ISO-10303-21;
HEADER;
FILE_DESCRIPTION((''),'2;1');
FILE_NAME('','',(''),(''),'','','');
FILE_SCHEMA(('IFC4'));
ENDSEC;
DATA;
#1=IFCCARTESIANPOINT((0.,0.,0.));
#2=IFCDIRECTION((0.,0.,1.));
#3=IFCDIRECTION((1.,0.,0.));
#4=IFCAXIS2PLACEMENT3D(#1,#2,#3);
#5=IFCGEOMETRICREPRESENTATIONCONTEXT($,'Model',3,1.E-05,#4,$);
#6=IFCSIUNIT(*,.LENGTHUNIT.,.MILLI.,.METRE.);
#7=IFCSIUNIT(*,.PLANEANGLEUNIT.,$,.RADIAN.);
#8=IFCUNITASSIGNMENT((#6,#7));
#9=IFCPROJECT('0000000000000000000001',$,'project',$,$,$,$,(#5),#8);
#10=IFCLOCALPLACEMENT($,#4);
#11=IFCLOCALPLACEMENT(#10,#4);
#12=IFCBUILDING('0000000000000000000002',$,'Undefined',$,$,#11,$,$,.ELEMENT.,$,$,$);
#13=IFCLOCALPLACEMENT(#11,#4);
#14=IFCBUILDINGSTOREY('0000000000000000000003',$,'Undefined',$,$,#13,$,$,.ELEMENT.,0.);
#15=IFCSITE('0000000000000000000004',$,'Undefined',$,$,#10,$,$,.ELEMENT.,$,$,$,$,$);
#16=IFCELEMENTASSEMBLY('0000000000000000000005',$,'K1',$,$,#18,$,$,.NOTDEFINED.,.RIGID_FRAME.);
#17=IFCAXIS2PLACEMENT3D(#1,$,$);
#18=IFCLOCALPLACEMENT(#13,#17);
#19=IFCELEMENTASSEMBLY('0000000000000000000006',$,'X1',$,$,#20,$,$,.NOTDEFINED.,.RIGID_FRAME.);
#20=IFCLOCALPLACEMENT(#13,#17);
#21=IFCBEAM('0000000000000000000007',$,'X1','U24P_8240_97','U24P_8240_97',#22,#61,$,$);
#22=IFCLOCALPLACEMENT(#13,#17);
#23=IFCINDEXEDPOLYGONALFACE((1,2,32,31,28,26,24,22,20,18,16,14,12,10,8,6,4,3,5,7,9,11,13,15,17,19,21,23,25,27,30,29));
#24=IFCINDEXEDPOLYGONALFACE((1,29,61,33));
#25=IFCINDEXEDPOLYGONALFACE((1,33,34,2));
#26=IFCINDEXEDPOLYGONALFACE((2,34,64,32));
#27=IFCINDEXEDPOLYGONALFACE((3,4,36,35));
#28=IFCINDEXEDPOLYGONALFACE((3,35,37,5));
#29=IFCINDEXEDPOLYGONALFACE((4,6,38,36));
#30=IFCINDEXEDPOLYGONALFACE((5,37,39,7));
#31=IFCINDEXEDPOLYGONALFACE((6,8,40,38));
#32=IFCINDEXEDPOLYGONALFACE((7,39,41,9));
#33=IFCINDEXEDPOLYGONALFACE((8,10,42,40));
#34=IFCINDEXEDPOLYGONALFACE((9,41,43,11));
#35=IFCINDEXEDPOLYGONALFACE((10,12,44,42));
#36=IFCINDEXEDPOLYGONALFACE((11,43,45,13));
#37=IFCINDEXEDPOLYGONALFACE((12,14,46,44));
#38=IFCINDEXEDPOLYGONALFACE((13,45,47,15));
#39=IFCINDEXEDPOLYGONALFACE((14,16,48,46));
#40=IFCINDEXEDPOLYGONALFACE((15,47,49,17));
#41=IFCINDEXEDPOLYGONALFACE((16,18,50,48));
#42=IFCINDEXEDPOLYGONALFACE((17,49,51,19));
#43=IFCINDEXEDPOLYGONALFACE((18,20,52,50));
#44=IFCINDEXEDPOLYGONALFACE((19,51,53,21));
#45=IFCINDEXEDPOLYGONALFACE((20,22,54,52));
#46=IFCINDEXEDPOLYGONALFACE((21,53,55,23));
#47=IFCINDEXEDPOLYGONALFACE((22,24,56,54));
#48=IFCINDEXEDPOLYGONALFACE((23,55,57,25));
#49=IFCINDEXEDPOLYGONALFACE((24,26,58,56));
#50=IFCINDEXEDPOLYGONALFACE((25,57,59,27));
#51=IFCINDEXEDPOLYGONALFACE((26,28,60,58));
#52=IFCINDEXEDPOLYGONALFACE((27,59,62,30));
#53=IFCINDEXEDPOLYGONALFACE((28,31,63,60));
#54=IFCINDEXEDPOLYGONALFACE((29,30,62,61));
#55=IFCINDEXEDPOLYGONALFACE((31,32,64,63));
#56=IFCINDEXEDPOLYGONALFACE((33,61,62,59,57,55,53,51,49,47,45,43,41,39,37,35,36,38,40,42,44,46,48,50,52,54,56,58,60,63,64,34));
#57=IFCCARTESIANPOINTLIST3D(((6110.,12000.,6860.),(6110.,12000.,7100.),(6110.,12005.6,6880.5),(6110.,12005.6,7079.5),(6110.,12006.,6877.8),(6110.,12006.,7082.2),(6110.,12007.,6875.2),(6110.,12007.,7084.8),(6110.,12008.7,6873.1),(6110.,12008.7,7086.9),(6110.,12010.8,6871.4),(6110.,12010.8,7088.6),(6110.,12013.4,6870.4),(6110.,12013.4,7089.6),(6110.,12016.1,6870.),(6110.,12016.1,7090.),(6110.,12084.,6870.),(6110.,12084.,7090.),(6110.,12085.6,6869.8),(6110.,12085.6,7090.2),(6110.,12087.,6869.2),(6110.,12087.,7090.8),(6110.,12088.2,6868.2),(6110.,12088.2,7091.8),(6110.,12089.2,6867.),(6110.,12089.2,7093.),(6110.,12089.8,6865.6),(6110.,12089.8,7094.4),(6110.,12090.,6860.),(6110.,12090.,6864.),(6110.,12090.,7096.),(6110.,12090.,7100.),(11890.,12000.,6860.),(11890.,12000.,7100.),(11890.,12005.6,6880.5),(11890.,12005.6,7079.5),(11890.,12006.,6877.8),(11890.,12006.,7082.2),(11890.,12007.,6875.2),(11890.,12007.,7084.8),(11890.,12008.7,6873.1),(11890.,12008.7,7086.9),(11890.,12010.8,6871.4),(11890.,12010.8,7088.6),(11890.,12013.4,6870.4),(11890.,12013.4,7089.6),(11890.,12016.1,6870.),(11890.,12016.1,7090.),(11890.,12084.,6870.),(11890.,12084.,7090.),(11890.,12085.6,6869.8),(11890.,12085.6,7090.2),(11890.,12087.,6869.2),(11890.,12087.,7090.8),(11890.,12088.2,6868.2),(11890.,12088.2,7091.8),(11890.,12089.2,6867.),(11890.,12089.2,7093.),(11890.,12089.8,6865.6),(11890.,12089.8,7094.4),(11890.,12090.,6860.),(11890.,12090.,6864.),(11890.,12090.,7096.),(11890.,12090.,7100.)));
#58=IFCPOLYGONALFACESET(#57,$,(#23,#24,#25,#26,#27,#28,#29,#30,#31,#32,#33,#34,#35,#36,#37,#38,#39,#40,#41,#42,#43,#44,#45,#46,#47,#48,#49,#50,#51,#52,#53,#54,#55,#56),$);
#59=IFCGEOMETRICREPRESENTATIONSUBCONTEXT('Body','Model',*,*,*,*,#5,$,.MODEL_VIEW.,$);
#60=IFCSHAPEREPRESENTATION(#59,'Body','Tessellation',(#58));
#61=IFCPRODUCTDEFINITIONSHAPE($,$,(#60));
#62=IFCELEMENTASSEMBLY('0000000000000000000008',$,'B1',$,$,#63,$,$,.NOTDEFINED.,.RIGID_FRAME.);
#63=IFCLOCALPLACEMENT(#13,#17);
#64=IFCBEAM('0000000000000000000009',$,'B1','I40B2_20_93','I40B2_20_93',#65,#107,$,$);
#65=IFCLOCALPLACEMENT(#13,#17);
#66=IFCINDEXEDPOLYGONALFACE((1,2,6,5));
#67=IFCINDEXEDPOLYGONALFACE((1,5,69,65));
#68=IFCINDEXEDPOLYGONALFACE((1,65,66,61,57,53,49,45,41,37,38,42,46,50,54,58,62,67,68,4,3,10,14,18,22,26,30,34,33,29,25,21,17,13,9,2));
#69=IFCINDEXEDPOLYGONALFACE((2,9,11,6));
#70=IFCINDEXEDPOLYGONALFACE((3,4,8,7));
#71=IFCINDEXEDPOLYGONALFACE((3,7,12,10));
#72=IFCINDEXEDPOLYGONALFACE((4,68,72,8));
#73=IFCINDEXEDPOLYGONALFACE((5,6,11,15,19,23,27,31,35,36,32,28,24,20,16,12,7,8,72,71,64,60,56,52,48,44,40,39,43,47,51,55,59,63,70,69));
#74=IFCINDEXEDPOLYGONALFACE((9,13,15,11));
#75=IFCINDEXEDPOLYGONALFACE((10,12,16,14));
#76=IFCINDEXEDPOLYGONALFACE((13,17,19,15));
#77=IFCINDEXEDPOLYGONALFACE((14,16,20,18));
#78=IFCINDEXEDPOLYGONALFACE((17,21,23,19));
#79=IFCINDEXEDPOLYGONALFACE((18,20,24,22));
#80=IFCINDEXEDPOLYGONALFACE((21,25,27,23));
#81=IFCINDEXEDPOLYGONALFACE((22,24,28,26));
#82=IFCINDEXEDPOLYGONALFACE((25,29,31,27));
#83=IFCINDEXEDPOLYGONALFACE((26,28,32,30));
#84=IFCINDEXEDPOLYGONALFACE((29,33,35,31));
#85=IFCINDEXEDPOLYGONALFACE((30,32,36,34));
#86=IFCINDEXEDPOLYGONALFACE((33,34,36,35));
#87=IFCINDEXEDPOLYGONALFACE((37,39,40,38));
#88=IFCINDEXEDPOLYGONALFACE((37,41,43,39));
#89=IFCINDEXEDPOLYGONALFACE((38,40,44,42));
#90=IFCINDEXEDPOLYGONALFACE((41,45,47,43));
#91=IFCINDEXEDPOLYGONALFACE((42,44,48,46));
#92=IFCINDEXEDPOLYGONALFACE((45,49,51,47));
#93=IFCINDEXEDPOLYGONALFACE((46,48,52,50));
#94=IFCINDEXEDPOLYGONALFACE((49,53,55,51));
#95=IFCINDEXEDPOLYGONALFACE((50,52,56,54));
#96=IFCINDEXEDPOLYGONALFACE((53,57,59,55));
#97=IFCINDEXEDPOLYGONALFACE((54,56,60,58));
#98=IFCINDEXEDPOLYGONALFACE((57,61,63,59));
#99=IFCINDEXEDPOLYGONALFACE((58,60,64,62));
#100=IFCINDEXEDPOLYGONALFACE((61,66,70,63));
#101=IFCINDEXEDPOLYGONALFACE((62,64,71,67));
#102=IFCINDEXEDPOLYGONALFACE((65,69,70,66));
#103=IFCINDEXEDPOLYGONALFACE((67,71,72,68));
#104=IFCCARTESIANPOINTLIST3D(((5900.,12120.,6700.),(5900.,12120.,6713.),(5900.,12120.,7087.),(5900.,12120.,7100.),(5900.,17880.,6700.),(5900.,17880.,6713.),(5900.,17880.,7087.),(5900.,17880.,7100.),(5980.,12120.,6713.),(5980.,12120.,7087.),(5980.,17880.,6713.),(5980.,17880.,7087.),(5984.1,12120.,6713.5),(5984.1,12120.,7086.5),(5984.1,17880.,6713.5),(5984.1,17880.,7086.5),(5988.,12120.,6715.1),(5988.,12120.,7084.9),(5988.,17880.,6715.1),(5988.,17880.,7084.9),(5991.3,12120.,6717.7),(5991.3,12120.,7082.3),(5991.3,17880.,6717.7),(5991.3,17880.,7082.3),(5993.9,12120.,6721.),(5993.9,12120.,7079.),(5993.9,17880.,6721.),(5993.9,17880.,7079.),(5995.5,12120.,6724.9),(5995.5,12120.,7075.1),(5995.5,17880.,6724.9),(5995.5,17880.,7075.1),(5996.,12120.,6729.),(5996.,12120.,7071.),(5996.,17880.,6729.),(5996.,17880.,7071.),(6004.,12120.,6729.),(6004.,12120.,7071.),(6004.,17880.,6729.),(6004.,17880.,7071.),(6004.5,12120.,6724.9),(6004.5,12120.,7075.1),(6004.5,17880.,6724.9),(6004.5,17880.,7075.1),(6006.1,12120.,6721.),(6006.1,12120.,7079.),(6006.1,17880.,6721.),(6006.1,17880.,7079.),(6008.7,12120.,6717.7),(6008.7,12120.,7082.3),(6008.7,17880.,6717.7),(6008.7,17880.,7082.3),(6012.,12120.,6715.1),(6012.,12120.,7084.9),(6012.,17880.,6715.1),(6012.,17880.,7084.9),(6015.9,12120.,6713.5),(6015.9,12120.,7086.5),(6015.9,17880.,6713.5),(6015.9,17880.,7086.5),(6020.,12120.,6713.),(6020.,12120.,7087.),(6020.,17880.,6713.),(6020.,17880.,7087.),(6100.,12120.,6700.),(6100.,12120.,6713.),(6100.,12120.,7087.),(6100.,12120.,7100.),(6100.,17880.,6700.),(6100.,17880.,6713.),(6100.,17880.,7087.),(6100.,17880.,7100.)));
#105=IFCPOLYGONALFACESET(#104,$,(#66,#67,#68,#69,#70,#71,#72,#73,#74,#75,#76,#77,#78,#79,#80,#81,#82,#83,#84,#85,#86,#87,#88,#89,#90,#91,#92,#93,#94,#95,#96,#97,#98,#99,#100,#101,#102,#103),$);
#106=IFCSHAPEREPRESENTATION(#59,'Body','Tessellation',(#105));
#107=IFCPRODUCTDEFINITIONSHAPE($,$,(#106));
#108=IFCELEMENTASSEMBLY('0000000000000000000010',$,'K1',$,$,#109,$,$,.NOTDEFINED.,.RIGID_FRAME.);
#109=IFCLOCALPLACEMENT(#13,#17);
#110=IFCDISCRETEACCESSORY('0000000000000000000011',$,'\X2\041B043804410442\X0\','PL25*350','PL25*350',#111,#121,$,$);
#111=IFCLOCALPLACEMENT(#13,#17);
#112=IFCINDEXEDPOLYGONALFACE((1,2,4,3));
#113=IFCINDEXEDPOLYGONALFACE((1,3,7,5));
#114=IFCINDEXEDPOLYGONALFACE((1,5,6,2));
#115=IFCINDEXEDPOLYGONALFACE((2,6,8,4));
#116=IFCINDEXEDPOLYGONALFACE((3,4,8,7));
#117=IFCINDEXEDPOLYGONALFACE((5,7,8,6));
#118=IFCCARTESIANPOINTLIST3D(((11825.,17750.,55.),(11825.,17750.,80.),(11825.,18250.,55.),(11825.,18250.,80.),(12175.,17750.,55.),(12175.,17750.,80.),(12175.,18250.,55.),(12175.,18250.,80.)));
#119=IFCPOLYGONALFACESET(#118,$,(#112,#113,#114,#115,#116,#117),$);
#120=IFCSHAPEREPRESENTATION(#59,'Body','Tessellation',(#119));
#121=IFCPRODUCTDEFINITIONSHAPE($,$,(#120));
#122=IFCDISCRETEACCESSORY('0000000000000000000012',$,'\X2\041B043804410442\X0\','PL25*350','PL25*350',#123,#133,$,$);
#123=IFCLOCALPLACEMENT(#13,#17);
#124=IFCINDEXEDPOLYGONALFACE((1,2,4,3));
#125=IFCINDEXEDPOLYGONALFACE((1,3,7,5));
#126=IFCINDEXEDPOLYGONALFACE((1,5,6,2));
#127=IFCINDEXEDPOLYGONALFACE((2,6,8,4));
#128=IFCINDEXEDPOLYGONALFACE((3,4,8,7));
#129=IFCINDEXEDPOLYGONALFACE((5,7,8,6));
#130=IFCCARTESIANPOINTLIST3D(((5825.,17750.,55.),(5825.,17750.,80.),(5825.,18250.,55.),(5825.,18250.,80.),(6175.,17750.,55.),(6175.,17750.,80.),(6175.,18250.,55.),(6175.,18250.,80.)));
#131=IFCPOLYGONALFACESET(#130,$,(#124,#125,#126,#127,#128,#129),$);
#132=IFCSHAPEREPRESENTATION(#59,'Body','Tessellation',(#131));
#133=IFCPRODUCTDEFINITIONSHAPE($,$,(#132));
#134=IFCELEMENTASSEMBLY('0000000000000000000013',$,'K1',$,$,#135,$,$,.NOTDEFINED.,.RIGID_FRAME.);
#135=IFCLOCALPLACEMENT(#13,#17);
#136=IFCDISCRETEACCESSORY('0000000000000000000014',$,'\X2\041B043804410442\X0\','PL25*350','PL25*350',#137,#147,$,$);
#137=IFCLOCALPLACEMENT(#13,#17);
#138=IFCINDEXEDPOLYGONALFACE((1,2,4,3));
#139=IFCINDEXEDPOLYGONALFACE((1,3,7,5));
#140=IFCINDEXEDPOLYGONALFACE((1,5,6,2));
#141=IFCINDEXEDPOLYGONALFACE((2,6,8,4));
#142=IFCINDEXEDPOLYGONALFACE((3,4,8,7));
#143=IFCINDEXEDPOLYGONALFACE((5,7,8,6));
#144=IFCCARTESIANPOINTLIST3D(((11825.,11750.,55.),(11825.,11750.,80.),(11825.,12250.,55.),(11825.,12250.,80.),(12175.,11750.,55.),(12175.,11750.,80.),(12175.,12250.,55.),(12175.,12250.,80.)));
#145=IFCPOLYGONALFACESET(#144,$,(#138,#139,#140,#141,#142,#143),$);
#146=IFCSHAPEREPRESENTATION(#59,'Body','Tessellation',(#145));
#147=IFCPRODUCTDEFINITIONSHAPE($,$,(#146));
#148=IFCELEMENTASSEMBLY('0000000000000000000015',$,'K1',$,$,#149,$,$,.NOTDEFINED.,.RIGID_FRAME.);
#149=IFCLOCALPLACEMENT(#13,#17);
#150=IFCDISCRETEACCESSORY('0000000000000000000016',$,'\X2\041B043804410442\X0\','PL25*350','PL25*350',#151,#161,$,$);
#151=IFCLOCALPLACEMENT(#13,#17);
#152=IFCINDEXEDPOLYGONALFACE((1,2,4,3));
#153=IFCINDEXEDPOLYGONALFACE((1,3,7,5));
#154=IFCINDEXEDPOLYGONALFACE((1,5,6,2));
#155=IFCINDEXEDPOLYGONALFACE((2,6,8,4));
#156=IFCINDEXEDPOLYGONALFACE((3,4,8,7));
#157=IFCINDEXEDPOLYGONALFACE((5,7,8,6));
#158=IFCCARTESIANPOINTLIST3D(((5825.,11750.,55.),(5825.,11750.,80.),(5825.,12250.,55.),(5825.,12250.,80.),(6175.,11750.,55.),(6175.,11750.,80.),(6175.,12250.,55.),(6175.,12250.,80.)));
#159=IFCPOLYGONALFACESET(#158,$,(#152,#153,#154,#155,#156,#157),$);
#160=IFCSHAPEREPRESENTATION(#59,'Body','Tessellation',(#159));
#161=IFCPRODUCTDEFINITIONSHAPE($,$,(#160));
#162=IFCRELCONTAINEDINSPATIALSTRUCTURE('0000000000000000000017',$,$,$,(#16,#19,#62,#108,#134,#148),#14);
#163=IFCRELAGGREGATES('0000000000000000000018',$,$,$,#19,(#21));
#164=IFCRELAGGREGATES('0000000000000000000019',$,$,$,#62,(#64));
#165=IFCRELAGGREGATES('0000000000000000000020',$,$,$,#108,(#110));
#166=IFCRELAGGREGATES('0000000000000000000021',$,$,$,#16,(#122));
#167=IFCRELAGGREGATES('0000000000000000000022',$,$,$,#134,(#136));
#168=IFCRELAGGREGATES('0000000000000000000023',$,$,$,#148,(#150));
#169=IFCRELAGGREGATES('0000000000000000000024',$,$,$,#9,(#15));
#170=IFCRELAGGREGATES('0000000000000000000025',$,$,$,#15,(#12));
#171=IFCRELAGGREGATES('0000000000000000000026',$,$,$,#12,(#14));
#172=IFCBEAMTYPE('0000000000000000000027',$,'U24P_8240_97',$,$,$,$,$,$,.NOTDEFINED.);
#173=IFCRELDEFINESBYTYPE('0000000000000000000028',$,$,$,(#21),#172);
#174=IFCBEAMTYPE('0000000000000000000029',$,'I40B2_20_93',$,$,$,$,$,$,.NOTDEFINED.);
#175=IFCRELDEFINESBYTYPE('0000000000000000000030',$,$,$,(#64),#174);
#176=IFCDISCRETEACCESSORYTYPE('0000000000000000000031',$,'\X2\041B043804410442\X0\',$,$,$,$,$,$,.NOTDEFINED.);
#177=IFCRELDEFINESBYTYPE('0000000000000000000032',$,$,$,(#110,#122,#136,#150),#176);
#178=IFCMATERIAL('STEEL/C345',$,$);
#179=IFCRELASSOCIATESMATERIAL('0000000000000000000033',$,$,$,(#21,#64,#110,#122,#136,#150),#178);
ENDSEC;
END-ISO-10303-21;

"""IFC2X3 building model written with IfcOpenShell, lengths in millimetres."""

from ifc_helpers import new_model, si_unit, frame, origin_with_axes, origin_2d_with_axis, place, context, subcontext, project, spatial, polyline, i_section, u_section, outline, extrude, material, type_object, element, aggregate, save


model = new_model("IFC2X3")

# Units and contexts
model_context = context("Model", 3, precision=1e-05, world=origin_with_axes())
body_context = subcontext(model_context, "Body", "Model", "MODEL_VIEW")
ifc_project = project(units=[si_unit("LENGTHUNIT", "METRE", prefix="MILLI"), si_unit("PLANEANGLEUNIT", "RADIAN")], contexts=[model_context])

# Site, building, storey
site_placement = place(None, origin_with_axes())
site = spatial("IfcSite", under=ifc_project, at=site_placement, Name="Undefined", CompositionType="ELEMENT")
building_placement = place(site_placement, origin_with_axes())
building = spatial("IfcBuilding", under=site, at=building_placement, Name="Undefined", CompositionType="ELEMENT")
storey_placement = place(building_placement, origin_with_axes())
storey = spatial("IfcBuildingStorey", under=building, at=storey_placement, Name="Undefined", CompositionType="ELEMENT", Elevation=0.0)

# Element assembly
assembly_1_placement = place(storey_placement, origin_with_axes())
assembly_1 = element("IfcElementAssembly", 1, at=assembly_1_placement, inside=storey, Name="K1", AssemblyPlace="NOTDEFINED", PredefinedType="RIGID_FRAME")
ifc_material_1 = material(Name="STEEL/C345")

# Element assemblies, beams
beam_type_1 = type_object("IfcBeamType", Name="U24P_8240_97", PredefinedType="NOTDEFINED")
assembly_2_placement = place(storey_placement, origin_with_axes())
assembly_2 = element("IfcElementAssembly", 2, at=assembly_2_placement, inside=storey, Name="X1", AssemblyPlace="NOTDEFINED", PredefinedType="RIGID_FRAME")
beam_1_placement = place(assembly_2_placement, frame((6110.0, 12045.0, 6980.0), z_axis=(0.0, 0.0, -1.0), x_axis=(1.0, 0.0, 0.0)))
beam_1 = element("IfcBeam", 3, at=beam_1_placement, type_object=beam_type_1, material=ifc_material_1, Name="X1", Description="U24P_8240_97", ObjectType="U24P_8240_97", context=body_context, shape_type="SweptSolid", body=[
    extrude(u_section(Depth=240.0, FlangeWidth=90.0, WebThickness=5.6, FlangeThickness=10.0, FilletRadius=10.5, EdgeRadius=6.0, at=origin_2d_with_axis()), frame((5780.0, 0.0, 0.0), z_axis=(-1.0, 0.0, 0.0), x_axis=(0.0, -1.0, 0.0)), (0.0, 0.0, 1.0), 5780.0),
])
aggregate(assembly_2, [beam_1])
assembly_3_placement = place(storey_placement, origin_with_axes())
assembly_3 = element("IfcElementAssembly", 4, at=assembly_3_placement, inside=storey, Name="B1", AssemblyPlace="NOTDEFINED", PredefinedType="RIGID_FRAME")
beam_type_2 = type_object("IfcBeamType", Name="I40B2_20_93", PredefinedType="NOTDEFINED")
beam_2_placement = place(assembly_3_placement, frame((6000.0, 12120.0, 6900.0), z_axis=(0.0, 0.0, 1.0), x_axis=(0.0, 1.0, 0.0)))
beam_2 = element("IfcBeam", 5, at=beam_2_placement, type_object=beam_type_2, material=ifc_material_1, Name="B1", Description="I40B2_20_93", ObjectType="I40B2_20_93", context=body_context, shape_type="SweptSolid", body=[
    extrude(i_section(OverallWidth=200.0, OverallDepth=400.0, WebThickness=8.0, FlangeThickness=13.0, FilletRadius=16.0, at=origin_2d_with_axis()), frame((5760.0, 0.0, 0.0), z_axis=(-1.0, 0.0, 0.0), x_axis=(0.0, -1.0, 0.0)), (0.0, 0.0, 1.0), 5760.0),
])
aggregate(assembly_3, [beam_2])

# Element assembly, discrete accessory
assembly_4_placement = place(storey_placement, origin_with_axes())
assembly_4 = element("IfcElementAssembly", 6, at=assembly_4_placement, inside=storey, Name="K1", AssemblyPlace="NOTDEFINED", PredefinedType="RIGID_FRAME")
discrete_accessory_type = type_object("IfcDiscreteAccessoryType", Name="Лист")
discrete_accessory_1_placement = place(assembly_4_placement, frame((11825.0, 18250.0, 67.5), z_axis=(0.0, 0.0, 1.0), x_axis=(0.0, -1.0, 0.0)))
discrete_accessory_1 = element("IfcDiscreteAccessory", 7, at=discrete_accessory_1_placement, type_object=discrete_accessory_type, material=ifc_material_1, Name="Лист", Description="PL25*350", ObjectType="PL25*350", context=body_context, shape_type="SweptSolid", body=[
    extrude(outline(polyline([(0.0, 0.0), (500.0, 0.0), (500.0, 350.0), (0.0, 350.0), (0.0, 0.0)])), frame((0.0, 0.0, -12.5), z_axis=(0.0, 0.0, 1.0), x_axis=(1.0, 0.0, 0.0)), (0.0, 0.0, 1.0), 25.0),
])
aggregate(assembly_4, [discrete_accessory_1])

# Discrete accessory
discrete_accessory_2_placement = place(assembly_1_placement, frame((5825.0, 18250.0, 67.5), z_axis=(0.0, 0.0, 1.0), x_axis=(0.0, -1.0, 0.0)))
discrete_accessory_2 = element("IfcDiscreteAccessory", 8, at=discrete_accessory_2_placement, type_object=discrete_accessory_type, material=ifc_material_1, Name="Лист", Description="PL25*350", ObjectType="PL25*350", context=body_context, shape_type="SweptSolid", body=[
    extrude(outline(polyline([(0.0, 0.0), (500.0, 0.0), (500.0, 350.0), (0.0, 350.0), (0.0, 0.0)])), frame((0.0, 0.0, -12.5), z_axis=(0.0, 0.0, 1.0), x_axis=(1.0, 0.0, 0.0)), (0.0, 0.0, 1.0), 25.0),
])
aggregate(assembly_1, [discrete_accessory_2])

# Element assemblies, discrete accessories
assembly_5_placement = place(storey_placement, origin_with_axes())
assembly_5 = element("IfcElementAssembly", 9, at=assembly_5_placement, inside=storey, Name="K1", AssemblyPlace="NOTDEFINED", PredefinedType="RIGID_FRAME")
discrete_accessory_3_placement = place(assembly_5_placement, frame((11825.0, 12250.0, 67.5), z_axis=(0.0, 0.0, 1.0), x_axis=(0.0, -1.0, 0.0)))
discrete_accessory_3 = element("IfcDiscreteAccessory", 10, at=discrete_accessory_3_placement, type_object=discrete_accessory_type, material=ifc_material_1, Name="Лист", Description="PL25*350", ObjectType="PL25*350", context=body_context, shape_type="SweptSolid", body=[
    extrude(outline(polyline([(0.0, 0.0), (500.0, 0.0), (500.0, 350.0), (0.0, 350.0), (0.0, 0.0)])), frame((0.0, 0.0, -12.5), z_axis=(0.0, 0.0, 1.0), x_axis=(1.0, 0.0, 0.0)), (0.0, 0.0, 1.0), 25.0),
])
aggregate(assembly_5, [discrete_accessory_3])
assembly_6_placement = place(storey_placement, origin_with_axes())
assembly_6 = element("IfcElementAssembly", 11, at=assembly_6_placement, inside=storey, Name="K1", AssemblyPlace="NOTDEFINED", PredefinedType="RIGID_FRAME")
discrete_accessory_4_placement = place(assembly_6_placement, frame((5825.0, 12250.0, 67.5), z_axis=(0.0, 0.0, 1.0), x_axis=(0.0, -1.0, 0.0)))
discrete_accessory_4 = element("IfcDiscreteAccessory", 12, at=discrete_accessory_4_placement, type_object=discrete_accessory_type, material=ifc_material_1, Name="Лист", Description="PL25*350", ObjectType="PL25*350", context=body_context, shape_type="SweptSolid", body=[
    extrude(outline(polyline([(0.0, 0.0), (500.0, 0.0), (500.0, 350.0), (0.0, 350.0), (0.0, 0.0)])), frame((0.0, 0.0, -12.5), z_axis=(0.0, 0.0, 1.0), x_axis=(1.0, 0.0, 0.0)), (0.0, 0.0, 1.0), 25.0),
])
aggregate(assembly_6, [discrete_accessory_4])

save(model, "model.ifc")
